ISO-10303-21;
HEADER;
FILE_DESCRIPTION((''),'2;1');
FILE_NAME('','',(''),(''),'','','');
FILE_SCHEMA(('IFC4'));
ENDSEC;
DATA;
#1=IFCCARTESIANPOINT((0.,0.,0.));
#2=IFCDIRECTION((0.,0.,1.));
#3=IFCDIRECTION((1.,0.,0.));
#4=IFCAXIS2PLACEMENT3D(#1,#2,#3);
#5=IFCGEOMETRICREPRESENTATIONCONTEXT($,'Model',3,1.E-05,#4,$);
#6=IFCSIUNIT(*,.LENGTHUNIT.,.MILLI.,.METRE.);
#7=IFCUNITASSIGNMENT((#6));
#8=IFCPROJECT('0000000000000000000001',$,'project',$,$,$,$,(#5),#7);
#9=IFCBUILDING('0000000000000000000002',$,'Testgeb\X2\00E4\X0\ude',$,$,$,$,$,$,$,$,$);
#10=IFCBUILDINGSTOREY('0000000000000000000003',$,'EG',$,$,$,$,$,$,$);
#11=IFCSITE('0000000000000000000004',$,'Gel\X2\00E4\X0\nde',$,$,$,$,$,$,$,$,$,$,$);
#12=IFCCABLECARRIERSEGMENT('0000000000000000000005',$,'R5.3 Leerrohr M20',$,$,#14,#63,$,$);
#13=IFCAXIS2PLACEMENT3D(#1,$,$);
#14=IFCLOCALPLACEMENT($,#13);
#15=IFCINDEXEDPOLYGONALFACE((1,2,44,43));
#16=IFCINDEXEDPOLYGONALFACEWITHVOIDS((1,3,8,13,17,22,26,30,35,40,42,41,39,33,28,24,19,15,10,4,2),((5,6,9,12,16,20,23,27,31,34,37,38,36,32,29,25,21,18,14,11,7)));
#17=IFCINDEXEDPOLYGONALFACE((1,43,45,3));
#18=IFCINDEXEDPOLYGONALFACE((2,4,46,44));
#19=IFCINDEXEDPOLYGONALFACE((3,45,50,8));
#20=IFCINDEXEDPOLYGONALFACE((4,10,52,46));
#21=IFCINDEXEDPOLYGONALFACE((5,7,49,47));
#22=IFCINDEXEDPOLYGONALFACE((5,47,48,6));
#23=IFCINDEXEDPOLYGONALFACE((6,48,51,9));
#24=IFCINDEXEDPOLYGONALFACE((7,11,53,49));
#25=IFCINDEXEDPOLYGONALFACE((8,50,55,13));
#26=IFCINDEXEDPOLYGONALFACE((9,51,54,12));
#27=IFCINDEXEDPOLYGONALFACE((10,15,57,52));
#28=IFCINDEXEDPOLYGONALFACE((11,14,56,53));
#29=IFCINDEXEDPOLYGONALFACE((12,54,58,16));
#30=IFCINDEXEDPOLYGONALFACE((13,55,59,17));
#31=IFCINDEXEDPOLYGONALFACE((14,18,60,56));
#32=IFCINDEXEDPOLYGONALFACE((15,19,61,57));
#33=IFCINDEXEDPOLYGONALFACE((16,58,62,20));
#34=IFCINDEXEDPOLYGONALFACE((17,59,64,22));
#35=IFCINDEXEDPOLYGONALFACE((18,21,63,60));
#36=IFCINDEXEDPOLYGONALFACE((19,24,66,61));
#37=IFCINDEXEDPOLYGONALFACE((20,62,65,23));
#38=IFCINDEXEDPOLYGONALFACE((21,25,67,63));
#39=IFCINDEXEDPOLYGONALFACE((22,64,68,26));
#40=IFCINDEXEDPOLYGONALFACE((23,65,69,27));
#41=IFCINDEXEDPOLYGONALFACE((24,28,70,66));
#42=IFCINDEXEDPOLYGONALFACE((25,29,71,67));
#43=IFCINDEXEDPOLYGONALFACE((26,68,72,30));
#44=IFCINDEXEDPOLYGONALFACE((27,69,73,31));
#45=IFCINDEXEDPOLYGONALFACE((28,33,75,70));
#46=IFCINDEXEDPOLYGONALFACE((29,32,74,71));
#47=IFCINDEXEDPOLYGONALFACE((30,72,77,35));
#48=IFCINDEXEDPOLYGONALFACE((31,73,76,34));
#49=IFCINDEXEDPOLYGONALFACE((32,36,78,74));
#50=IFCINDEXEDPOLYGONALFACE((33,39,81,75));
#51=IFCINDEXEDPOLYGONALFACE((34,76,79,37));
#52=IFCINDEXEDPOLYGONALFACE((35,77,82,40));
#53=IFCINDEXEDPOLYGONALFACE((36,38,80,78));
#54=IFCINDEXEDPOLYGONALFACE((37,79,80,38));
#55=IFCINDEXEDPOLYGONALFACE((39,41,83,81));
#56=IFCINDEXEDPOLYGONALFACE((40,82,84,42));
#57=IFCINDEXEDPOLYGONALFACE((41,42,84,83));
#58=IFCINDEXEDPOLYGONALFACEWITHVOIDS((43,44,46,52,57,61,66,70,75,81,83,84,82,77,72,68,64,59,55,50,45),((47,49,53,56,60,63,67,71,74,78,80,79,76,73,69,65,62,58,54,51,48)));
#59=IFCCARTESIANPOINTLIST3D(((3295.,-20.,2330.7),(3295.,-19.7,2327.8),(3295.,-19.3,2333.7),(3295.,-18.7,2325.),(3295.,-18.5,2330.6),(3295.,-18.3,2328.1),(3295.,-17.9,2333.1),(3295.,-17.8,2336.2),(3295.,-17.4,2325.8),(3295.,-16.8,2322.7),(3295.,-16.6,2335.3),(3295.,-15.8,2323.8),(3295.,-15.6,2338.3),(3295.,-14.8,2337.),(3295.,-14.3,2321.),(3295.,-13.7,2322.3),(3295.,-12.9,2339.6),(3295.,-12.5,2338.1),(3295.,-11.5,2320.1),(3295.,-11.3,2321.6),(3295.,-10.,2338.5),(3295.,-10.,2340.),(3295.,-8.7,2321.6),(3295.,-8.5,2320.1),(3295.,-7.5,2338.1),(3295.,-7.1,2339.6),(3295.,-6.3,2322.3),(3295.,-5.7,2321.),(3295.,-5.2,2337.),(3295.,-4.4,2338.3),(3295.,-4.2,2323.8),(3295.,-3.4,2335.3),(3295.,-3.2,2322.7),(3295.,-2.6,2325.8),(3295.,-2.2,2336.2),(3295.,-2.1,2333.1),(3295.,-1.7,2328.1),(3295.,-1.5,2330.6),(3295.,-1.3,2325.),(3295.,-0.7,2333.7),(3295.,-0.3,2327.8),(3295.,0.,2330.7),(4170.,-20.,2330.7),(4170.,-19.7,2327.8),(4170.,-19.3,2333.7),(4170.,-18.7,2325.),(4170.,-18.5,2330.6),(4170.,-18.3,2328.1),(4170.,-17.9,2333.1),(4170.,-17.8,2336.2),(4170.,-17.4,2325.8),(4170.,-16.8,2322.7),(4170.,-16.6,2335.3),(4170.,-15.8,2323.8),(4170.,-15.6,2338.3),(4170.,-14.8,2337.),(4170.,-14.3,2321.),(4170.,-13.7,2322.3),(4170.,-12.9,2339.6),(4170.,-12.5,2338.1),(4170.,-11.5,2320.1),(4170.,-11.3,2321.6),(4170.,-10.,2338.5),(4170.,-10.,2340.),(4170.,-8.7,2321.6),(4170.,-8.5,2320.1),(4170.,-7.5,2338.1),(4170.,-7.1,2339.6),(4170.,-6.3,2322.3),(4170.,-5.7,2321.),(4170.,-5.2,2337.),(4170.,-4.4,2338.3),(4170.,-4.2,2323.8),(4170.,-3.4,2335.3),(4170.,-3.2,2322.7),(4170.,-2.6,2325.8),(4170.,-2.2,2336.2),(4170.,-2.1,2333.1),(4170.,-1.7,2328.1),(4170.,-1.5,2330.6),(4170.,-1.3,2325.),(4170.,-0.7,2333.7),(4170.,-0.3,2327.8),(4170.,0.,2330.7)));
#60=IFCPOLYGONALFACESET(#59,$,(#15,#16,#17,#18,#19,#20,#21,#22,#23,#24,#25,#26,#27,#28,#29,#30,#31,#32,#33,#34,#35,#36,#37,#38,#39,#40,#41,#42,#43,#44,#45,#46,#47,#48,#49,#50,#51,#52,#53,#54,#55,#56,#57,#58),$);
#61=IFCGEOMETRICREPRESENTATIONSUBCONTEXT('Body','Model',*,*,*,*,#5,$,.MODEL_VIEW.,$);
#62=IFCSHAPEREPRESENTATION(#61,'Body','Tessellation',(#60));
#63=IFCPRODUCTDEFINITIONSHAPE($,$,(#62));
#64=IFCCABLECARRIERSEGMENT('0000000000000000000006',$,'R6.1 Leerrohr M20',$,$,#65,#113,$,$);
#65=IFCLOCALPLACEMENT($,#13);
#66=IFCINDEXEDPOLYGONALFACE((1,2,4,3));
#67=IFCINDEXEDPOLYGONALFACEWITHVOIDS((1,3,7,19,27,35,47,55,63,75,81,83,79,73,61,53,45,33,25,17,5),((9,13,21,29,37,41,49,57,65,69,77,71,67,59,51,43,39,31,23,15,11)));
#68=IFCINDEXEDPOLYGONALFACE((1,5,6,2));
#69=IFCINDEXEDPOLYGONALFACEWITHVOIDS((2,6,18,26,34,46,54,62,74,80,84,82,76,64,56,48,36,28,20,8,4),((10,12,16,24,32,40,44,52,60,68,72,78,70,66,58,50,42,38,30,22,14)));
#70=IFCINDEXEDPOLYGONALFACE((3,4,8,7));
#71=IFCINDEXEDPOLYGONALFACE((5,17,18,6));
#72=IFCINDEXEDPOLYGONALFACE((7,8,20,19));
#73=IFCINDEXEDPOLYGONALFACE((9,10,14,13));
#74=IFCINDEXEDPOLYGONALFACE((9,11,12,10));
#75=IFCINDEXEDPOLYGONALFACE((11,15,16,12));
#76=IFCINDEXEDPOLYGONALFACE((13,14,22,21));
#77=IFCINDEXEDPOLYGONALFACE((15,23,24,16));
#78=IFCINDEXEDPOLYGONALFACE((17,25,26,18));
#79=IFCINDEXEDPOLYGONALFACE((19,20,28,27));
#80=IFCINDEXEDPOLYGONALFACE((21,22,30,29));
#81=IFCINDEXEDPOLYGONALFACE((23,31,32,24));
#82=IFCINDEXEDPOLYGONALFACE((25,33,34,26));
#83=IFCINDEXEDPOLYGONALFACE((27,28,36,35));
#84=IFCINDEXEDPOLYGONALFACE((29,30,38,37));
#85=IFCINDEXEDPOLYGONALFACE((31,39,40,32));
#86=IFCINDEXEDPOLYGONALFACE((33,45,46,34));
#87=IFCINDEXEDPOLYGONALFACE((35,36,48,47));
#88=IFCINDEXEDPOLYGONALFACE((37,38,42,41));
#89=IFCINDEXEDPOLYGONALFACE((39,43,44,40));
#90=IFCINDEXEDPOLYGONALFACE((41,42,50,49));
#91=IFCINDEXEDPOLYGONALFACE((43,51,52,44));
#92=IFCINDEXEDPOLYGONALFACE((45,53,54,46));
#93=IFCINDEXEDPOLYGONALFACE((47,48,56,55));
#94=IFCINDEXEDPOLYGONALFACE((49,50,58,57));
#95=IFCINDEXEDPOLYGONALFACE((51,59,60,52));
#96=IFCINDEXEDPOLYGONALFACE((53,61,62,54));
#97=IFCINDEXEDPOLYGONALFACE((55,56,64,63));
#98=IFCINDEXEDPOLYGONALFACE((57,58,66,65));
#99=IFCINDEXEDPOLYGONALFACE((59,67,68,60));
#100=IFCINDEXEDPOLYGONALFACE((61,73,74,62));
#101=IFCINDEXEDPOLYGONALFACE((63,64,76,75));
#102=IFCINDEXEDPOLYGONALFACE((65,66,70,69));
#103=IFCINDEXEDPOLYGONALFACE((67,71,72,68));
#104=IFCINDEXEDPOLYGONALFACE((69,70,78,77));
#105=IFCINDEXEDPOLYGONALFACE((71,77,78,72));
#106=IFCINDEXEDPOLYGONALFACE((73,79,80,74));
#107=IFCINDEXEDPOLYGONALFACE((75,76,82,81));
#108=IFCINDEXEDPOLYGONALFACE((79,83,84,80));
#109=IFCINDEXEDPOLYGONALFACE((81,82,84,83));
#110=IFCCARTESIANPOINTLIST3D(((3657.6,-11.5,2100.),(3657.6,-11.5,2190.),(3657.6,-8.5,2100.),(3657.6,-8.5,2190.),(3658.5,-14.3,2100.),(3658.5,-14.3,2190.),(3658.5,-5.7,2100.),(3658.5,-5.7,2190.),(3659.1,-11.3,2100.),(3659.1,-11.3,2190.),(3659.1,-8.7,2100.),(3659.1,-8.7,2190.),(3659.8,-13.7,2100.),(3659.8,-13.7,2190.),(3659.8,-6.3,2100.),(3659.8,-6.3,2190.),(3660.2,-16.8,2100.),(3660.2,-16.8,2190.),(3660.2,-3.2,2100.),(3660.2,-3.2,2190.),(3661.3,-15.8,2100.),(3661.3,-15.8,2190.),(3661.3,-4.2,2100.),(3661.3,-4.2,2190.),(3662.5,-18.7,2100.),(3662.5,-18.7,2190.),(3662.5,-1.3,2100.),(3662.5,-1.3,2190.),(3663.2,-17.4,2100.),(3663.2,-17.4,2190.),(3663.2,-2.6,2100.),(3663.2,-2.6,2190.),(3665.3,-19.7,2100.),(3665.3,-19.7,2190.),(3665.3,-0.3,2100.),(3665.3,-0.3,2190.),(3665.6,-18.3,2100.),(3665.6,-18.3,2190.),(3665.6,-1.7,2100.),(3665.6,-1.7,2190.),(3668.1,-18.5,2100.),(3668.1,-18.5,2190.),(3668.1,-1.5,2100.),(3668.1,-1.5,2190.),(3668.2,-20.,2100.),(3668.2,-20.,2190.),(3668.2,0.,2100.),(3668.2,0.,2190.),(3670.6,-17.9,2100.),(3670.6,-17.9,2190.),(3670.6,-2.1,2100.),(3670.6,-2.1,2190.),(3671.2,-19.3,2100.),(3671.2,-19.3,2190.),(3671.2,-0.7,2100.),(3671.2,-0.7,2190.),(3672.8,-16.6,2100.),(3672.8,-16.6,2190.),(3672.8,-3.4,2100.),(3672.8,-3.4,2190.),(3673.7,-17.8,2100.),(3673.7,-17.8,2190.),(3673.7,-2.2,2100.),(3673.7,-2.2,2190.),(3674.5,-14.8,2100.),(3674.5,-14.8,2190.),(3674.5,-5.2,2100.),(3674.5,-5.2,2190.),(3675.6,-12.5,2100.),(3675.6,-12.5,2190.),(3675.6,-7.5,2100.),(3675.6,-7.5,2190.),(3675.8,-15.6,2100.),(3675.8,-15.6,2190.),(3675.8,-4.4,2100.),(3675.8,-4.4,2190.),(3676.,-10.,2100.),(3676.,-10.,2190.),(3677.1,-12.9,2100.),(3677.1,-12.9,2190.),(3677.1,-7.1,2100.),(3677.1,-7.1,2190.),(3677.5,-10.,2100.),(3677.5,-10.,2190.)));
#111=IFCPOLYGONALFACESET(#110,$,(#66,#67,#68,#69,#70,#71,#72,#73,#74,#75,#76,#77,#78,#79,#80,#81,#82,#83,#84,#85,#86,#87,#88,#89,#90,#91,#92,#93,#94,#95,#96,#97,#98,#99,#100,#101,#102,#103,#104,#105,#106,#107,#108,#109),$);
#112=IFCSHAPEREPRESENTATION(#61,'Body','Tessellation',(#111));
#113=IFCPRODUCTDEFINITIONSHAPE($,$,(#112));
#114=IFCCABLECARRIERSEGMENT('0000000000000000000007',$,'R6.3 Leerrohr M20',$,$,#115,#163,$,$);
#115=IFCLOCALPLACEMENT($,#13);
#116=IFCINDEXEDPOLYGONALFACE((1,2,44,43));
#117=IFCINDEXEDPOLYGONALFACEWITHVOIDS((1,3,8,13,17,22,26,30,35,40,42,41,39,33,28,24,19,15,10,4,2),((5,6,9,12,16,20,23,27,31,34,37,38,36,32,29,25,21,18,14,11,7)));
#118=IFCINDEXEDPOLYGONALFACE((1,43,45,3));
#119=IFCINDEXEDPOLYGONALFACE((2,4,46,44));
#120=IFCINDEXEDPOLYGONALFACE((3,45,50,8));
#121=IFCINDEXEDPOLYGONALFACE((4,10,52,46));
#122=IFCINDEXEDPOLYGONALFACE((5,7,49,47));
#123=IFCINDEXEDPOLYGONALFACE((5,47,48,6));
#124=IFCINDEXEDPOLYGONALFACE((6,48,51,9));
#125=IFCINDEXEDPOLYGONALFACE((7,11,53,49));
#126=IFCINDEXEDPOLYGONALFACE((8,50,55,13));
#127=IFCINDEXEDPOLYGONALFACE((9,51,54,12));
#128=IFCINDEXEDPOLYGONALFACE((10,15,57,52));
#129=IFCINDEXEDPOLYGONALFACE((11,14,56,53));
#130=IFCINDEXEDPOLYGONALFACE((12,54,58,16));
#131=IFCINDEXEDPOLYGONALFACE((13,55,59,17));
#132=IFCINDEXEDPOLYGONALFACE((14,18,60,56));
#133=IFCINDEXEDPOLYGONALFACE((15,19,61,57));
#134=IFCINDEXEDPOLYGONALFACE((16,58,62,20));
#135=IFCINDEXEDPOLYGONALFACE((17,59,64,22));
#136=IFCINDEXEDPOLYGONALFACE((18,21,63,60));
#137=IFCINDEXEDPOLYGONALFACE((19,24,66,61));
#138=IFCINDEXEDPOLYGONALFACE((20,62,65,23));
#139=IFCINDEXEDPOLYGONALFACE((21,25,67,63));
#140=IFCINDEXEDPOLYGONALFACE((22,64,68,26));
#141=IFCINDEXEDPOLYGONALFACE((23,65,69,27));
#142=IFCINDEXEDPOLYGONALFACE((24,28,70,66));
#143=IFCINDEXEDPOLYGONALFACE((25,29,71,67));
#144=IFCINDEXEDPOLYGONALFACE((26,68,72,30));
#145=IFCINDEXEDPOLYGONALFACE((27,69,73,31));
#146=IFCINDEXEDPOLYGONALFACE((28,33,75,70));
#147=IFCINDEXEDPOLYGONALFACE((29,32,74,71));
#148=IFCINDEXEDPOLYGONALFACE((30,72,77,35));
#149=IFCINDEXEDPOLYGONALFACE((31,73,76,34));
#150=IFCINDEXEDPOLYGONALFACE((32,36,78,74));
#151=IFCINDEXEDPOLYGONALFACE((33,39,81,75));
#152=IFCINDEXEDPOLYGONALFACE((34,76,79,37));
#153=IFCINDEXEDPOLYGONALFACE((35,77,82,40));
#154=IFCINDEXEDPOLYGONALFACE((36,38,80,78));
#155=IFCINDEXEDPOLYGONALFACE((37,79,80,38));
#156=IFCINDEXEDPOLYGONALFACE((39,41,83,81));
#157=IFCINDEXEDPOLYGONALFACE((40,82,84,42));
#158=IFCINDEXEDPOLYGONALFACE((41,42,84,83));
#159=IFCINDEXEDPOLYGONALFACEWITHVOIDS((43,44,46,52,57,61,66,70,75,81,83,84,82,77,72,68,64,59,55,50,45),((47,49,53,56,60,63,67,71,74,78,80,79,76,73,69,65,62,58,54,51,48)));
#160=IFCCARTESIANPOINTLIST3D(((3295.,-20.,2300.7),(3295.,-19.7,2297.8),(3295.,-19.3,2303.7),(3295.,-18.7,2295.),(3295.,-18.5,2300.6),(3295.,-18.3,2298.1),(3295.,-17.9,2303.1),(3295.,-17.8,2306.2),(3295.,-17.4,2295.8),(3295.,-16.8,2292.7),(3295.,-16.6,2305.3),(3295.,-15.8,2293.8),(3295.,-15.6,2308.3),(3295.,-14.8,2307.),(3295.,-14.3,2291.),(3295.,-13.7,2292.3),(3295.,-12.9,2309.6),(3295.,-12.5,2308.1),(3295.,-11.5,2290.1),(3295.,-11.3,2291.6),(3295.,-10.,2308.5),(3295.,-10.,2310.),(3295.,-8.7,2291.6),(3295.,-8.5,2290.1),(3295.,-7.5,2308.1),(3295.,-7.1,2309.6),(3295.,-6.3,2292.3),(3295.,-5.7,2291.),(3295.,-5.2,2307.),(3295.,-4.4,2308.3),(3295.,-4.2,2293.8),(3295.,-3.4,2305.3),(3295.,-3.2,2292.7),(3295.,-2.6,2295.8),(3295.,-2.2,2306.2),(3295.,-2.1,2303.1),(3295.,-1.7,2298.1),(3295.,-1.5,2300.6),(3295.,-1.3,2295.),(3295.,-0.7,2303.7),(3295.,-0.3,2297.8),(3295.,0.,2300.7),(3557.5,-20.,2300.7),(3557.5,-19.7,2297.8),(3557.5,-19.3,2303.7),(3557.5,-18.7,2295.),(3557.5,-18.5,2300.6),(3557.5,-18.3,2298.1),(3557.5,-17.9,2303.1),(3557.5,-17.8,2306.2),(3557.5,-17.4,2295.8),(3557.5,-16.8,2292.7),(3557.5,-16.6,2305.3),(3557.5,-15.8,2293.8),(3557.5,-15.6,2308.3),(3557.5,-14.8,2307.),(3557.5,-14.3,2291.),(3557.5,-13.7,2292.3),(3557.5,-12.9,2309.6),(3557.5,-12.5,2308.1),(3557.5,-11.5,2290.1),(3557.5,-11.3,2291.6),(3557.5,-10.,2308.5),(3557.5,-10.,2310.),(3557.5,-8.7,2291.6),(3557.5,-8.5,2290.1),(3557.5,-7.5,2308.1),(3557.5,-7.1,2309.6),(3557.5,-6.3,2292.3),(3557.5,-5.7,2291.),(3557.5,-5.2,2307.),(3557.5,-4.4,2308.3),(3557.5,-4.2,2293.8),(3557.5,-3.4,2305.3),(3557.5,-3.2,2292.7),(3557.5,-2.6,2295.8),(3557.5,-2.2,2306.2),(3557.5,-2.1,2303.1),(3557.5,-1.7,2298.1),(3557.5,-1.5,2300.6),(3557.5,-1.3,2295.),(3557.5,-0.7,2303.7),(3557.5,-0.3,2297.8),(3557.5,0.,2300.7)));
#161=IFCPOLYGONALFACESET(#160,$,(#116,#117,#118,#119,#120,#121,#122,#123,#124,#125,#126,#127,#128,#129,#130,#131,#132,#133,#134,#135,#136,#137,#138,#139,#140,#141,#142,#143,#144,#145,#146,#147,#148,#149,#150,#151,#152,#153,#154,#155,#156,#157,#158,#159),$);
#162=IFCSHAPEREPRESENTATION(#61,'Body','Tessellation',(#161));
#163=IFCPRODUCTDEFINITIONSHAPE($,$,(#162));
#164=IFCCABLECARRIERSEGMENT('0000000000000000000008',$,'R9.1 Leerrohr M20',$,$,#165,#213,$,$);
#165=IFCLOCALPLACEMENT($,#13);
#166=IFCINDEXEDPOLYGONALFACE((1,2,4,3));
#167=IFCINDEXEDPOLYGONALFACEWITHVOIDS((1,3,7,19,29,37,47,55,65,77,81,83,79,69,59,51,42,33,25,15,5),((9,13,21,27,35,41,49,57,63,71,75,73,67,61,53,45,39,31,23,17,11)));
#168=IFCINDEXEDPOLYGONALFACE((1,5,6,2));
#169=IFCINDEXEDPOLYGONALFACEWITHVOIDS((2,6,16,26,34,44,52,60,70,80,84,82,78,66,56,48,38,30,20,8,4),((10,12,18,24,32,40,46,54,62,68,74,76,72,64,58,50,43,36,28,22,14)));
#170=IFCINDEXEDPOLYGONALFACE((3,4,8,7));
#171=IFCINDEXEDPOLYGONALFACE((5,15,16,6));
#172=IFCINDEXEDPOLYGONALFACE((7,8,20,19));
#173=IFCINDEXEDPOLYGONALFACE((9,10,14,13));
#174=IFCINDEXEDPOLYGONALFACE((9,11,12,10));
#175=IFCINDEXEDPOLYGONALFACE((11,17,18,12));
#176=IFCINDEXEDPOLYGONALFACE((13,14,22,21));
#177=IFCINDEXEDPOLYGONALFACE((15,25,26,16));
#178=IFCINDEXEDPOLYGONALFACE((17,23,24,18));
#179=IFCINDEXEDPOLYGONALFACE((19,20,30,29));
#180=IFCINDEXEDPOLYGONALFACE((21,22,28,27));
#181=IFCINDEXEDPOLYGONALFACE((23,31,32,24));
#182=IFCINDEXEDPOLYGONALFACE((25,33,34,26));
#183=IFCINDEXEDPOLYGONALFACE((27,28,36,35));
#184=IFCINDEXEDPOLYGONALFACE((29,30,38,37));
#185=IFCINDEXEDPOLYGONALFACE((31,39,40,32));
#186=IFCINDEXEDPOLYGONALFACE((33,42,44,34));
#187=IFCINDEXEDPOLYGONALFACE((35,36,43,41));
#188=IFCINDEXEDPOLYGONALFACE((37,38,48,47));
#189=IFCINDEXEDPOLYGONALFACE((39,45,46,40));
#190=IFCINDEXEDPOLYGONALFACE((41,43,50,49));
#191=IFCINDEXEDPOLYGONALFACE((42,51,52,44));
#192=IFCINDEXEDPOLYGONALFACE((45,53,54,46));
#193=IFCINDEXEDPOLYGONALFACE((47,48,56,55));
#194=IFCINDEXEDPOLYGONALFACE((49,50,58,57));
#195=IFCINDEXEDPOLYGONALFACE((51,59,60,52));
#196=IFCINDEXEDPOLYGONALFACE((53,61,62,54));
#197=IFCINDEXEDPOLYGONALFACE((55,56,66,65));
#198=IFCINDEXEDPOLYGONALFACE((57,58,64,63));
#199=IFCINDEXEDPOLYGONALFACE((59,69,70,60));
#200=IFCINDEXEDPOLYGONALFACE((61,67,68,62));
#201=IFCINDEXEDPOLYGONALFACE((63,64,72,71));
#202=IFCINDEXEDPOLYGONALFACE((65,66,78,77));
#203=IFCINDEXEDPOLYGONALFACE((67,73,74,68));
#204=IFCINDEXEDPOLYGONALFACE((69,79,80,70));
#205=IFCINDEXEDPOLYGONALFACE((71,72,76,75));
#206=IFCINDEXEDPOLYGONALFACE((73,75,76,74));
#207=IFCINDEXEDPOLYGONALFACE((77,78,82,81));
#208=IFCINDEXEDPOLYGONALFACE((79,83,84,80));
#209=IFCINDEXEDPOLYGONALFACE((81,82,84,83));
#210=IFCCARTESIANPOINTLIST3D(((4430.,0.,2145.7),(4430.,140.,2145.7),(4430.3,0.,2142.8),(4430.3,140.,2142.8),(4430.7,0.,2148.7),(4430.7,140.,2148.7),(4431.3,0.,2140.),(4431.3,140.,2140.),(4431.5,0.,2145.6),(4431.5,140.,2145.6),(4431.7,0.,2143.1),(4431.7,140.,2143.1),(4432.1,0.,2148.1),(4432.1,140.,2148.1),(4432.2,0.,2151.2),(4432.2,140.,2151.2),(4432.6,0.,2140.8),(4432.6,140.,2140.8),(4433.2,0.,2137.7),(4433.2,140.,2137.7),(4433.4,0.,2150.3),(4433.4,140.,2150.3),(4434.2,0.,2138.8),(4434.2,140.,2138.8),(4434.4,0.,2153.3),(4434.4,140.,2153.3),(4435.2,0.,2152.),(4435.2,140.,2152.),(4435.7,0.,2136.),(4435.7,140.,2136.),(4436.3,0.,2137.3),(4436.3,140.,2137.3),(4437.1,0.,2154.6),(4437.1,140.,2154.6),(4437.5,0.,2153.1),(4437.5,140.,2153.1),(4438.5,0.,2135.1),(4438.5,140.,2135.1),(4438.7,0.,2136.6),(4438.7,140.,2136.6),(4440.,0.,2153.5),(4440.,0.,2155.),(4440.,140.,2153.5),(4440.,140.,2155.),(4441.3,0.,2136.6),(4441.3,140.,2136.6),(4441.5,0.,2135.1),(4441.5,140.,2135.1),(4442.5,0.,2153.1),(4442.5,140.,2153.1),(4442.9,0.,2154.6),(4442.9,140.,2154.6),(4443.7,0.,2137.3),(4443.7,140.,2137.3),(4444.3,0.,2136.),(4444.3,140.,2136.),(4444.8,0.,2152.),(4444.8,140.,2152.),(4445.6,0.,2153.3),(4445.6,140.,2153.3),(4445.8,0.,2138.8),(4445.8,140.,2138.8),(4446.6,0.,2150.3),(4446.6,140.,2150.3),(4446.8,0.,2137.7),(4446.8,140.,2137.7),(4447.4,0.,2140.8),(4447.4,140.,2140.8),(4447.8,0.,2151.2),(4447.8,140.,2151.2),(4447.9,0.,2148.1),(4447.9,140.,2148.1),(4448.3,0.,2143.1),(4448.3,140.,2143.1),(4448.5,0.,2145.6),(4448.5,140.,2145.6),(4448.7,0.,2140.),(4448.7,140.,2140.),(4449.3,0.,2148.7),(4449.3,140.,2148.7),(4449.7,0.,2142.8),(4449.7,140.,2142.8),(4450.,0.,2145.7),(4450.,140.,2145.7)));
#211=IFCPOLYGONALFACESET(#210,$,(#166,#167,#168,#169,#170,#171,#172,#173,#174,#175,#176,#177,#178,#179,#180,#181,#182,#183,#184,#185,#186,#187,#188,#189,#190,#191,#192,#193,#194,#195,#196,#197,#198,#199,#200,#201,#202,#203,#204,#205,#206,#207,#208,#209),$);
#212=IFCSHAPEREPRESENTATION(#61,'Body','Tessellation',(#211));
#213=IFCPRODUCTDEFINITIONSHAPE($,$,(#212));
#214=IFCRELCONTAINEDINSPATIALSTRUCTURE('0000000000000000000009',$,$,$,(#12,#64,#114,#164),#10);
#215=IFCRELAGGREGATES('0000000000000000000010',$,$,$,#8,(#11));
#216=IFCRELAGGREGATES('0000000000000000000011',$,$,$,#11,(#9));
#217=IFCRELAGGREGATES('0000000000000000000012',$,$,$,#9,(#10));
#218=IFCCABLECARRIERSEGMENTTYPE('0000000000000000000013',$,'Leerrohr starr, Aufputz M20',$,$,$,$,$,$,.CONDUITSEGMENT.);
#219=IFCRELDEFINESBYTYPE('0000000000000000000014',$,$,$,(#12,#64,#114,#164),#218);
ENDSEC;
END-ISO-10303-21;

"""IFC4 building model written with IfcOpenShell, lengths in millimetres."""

from ifc_helpers import new_model, si_unit, frame, origin_with_axes, place, context, subcontext, project, spatial, hollow_circle, extrude, type_object, element, save


model = new_model("IFC4")

# Units and contexts
model_context = context("Model", 3, precision=1e-05, world=origin_with_axes())
body_context = subcontext(model_context, "Body", "Model", "MODEL_VIEW")
ifc_project = project(units=[si_unit("LENGTHUNIT", "METRE", prefix="MILLI")], contexts=[model_context])

# Site, building, storey
site = spatial("IfcSite", under=ifc_project, Name="Gelände")
building = spatial("IfcBuilding", under=site, Name="Testgebäude")
storey = spatial("IfcBuildingStorey", under=building, Name="EG")

# Cable carrier segments
cable_carrier_segment_type_1 = type_object("IfcCableCarrierSegmentType", Name="Leerrohr starr, Aufputz M20", PredefinedType="CONDUITSEGMENT")
cable_carrier_segment_1_placement = place(None, frame((4170.0, -10.0, 2330.0), z_axis=(-1.0, 0.0, 0.0), x_axis=(0.0, 0.0, 1.0)))
element("IfcCableCarrierSegment", 1, at=cable_carrier_segment_1_placement, inside=storey, type_object=cable_carrier_segment_type_1, Name="R5.3 Leerrohr M20", context=body_context, shape_type="SweptSolid", body=[
    extrude(hollow_circle(Radius=10.0, WallThickness=1.5), None, (0.0, 0.0, 1.0), 875.0),
])
cable_carrier_segment_2_placement = place(None, frame((3667.5, -10.0, 2100.0), z_axis=(0.0, 0.0, 1.0), x_axis=(1.0, 0.0, 0.0)))
element("IfcCableCarrierSegment", 2, at=cable_carrier_segment_2_placement, inside=storey, type_object=cable_carrier_segment_type_1, Name="R6.1 Leerrohr M20", context=body_context, shape_type="SweptSolid", body=[
    extrude(hollow_circle(Radius=10.0, WallThickness=1.5), None, (0.0, 0.0, 1.0), 90.0),
])
cable_carrier_segment_3_placement = place(None, frame((3557.5, -10.0, 2300.0), z_axis=(-1.0, 0.0, 0.0), x_axis=(0.0, 0.0, 1.0)))
element("IfcCableCarrierSegment", 3, at=cable_carrier_segment_3_placement, inside=storey, type_object=cable_carrier_segment_type_1, Name="R6.3 Leerrohr M20", context=body_context, shape_type="SweptSolid", body=[
    extrude(hollow_circle(Radius=10.0, WallThickness=1.5), None, (0.0, 0.0, 1.0), 262.5),
])
cable_carrier_segment_4_placement = place(None, frame((4440.0, 0.0, 2145.0), z_axis=(0.0, 1.0, 0.0), x_axis=(0.0, 0.0, 1.0)))
element("IfcCableCarrierSegment", 4, at=cable_carrier_segment_4_placement, inside=storey, type_object=cable_carrier_segment_type_1, Name="R9.1 Leerrohr M20", context=body_context, shape_type="SweptSolid", body=[
    extrude(hollow_circle(Radius=10.0, WallThickness=1.5), None, (0.0, 0.0, 1.0), 140.0),
])

save(model, "model.ifc")
